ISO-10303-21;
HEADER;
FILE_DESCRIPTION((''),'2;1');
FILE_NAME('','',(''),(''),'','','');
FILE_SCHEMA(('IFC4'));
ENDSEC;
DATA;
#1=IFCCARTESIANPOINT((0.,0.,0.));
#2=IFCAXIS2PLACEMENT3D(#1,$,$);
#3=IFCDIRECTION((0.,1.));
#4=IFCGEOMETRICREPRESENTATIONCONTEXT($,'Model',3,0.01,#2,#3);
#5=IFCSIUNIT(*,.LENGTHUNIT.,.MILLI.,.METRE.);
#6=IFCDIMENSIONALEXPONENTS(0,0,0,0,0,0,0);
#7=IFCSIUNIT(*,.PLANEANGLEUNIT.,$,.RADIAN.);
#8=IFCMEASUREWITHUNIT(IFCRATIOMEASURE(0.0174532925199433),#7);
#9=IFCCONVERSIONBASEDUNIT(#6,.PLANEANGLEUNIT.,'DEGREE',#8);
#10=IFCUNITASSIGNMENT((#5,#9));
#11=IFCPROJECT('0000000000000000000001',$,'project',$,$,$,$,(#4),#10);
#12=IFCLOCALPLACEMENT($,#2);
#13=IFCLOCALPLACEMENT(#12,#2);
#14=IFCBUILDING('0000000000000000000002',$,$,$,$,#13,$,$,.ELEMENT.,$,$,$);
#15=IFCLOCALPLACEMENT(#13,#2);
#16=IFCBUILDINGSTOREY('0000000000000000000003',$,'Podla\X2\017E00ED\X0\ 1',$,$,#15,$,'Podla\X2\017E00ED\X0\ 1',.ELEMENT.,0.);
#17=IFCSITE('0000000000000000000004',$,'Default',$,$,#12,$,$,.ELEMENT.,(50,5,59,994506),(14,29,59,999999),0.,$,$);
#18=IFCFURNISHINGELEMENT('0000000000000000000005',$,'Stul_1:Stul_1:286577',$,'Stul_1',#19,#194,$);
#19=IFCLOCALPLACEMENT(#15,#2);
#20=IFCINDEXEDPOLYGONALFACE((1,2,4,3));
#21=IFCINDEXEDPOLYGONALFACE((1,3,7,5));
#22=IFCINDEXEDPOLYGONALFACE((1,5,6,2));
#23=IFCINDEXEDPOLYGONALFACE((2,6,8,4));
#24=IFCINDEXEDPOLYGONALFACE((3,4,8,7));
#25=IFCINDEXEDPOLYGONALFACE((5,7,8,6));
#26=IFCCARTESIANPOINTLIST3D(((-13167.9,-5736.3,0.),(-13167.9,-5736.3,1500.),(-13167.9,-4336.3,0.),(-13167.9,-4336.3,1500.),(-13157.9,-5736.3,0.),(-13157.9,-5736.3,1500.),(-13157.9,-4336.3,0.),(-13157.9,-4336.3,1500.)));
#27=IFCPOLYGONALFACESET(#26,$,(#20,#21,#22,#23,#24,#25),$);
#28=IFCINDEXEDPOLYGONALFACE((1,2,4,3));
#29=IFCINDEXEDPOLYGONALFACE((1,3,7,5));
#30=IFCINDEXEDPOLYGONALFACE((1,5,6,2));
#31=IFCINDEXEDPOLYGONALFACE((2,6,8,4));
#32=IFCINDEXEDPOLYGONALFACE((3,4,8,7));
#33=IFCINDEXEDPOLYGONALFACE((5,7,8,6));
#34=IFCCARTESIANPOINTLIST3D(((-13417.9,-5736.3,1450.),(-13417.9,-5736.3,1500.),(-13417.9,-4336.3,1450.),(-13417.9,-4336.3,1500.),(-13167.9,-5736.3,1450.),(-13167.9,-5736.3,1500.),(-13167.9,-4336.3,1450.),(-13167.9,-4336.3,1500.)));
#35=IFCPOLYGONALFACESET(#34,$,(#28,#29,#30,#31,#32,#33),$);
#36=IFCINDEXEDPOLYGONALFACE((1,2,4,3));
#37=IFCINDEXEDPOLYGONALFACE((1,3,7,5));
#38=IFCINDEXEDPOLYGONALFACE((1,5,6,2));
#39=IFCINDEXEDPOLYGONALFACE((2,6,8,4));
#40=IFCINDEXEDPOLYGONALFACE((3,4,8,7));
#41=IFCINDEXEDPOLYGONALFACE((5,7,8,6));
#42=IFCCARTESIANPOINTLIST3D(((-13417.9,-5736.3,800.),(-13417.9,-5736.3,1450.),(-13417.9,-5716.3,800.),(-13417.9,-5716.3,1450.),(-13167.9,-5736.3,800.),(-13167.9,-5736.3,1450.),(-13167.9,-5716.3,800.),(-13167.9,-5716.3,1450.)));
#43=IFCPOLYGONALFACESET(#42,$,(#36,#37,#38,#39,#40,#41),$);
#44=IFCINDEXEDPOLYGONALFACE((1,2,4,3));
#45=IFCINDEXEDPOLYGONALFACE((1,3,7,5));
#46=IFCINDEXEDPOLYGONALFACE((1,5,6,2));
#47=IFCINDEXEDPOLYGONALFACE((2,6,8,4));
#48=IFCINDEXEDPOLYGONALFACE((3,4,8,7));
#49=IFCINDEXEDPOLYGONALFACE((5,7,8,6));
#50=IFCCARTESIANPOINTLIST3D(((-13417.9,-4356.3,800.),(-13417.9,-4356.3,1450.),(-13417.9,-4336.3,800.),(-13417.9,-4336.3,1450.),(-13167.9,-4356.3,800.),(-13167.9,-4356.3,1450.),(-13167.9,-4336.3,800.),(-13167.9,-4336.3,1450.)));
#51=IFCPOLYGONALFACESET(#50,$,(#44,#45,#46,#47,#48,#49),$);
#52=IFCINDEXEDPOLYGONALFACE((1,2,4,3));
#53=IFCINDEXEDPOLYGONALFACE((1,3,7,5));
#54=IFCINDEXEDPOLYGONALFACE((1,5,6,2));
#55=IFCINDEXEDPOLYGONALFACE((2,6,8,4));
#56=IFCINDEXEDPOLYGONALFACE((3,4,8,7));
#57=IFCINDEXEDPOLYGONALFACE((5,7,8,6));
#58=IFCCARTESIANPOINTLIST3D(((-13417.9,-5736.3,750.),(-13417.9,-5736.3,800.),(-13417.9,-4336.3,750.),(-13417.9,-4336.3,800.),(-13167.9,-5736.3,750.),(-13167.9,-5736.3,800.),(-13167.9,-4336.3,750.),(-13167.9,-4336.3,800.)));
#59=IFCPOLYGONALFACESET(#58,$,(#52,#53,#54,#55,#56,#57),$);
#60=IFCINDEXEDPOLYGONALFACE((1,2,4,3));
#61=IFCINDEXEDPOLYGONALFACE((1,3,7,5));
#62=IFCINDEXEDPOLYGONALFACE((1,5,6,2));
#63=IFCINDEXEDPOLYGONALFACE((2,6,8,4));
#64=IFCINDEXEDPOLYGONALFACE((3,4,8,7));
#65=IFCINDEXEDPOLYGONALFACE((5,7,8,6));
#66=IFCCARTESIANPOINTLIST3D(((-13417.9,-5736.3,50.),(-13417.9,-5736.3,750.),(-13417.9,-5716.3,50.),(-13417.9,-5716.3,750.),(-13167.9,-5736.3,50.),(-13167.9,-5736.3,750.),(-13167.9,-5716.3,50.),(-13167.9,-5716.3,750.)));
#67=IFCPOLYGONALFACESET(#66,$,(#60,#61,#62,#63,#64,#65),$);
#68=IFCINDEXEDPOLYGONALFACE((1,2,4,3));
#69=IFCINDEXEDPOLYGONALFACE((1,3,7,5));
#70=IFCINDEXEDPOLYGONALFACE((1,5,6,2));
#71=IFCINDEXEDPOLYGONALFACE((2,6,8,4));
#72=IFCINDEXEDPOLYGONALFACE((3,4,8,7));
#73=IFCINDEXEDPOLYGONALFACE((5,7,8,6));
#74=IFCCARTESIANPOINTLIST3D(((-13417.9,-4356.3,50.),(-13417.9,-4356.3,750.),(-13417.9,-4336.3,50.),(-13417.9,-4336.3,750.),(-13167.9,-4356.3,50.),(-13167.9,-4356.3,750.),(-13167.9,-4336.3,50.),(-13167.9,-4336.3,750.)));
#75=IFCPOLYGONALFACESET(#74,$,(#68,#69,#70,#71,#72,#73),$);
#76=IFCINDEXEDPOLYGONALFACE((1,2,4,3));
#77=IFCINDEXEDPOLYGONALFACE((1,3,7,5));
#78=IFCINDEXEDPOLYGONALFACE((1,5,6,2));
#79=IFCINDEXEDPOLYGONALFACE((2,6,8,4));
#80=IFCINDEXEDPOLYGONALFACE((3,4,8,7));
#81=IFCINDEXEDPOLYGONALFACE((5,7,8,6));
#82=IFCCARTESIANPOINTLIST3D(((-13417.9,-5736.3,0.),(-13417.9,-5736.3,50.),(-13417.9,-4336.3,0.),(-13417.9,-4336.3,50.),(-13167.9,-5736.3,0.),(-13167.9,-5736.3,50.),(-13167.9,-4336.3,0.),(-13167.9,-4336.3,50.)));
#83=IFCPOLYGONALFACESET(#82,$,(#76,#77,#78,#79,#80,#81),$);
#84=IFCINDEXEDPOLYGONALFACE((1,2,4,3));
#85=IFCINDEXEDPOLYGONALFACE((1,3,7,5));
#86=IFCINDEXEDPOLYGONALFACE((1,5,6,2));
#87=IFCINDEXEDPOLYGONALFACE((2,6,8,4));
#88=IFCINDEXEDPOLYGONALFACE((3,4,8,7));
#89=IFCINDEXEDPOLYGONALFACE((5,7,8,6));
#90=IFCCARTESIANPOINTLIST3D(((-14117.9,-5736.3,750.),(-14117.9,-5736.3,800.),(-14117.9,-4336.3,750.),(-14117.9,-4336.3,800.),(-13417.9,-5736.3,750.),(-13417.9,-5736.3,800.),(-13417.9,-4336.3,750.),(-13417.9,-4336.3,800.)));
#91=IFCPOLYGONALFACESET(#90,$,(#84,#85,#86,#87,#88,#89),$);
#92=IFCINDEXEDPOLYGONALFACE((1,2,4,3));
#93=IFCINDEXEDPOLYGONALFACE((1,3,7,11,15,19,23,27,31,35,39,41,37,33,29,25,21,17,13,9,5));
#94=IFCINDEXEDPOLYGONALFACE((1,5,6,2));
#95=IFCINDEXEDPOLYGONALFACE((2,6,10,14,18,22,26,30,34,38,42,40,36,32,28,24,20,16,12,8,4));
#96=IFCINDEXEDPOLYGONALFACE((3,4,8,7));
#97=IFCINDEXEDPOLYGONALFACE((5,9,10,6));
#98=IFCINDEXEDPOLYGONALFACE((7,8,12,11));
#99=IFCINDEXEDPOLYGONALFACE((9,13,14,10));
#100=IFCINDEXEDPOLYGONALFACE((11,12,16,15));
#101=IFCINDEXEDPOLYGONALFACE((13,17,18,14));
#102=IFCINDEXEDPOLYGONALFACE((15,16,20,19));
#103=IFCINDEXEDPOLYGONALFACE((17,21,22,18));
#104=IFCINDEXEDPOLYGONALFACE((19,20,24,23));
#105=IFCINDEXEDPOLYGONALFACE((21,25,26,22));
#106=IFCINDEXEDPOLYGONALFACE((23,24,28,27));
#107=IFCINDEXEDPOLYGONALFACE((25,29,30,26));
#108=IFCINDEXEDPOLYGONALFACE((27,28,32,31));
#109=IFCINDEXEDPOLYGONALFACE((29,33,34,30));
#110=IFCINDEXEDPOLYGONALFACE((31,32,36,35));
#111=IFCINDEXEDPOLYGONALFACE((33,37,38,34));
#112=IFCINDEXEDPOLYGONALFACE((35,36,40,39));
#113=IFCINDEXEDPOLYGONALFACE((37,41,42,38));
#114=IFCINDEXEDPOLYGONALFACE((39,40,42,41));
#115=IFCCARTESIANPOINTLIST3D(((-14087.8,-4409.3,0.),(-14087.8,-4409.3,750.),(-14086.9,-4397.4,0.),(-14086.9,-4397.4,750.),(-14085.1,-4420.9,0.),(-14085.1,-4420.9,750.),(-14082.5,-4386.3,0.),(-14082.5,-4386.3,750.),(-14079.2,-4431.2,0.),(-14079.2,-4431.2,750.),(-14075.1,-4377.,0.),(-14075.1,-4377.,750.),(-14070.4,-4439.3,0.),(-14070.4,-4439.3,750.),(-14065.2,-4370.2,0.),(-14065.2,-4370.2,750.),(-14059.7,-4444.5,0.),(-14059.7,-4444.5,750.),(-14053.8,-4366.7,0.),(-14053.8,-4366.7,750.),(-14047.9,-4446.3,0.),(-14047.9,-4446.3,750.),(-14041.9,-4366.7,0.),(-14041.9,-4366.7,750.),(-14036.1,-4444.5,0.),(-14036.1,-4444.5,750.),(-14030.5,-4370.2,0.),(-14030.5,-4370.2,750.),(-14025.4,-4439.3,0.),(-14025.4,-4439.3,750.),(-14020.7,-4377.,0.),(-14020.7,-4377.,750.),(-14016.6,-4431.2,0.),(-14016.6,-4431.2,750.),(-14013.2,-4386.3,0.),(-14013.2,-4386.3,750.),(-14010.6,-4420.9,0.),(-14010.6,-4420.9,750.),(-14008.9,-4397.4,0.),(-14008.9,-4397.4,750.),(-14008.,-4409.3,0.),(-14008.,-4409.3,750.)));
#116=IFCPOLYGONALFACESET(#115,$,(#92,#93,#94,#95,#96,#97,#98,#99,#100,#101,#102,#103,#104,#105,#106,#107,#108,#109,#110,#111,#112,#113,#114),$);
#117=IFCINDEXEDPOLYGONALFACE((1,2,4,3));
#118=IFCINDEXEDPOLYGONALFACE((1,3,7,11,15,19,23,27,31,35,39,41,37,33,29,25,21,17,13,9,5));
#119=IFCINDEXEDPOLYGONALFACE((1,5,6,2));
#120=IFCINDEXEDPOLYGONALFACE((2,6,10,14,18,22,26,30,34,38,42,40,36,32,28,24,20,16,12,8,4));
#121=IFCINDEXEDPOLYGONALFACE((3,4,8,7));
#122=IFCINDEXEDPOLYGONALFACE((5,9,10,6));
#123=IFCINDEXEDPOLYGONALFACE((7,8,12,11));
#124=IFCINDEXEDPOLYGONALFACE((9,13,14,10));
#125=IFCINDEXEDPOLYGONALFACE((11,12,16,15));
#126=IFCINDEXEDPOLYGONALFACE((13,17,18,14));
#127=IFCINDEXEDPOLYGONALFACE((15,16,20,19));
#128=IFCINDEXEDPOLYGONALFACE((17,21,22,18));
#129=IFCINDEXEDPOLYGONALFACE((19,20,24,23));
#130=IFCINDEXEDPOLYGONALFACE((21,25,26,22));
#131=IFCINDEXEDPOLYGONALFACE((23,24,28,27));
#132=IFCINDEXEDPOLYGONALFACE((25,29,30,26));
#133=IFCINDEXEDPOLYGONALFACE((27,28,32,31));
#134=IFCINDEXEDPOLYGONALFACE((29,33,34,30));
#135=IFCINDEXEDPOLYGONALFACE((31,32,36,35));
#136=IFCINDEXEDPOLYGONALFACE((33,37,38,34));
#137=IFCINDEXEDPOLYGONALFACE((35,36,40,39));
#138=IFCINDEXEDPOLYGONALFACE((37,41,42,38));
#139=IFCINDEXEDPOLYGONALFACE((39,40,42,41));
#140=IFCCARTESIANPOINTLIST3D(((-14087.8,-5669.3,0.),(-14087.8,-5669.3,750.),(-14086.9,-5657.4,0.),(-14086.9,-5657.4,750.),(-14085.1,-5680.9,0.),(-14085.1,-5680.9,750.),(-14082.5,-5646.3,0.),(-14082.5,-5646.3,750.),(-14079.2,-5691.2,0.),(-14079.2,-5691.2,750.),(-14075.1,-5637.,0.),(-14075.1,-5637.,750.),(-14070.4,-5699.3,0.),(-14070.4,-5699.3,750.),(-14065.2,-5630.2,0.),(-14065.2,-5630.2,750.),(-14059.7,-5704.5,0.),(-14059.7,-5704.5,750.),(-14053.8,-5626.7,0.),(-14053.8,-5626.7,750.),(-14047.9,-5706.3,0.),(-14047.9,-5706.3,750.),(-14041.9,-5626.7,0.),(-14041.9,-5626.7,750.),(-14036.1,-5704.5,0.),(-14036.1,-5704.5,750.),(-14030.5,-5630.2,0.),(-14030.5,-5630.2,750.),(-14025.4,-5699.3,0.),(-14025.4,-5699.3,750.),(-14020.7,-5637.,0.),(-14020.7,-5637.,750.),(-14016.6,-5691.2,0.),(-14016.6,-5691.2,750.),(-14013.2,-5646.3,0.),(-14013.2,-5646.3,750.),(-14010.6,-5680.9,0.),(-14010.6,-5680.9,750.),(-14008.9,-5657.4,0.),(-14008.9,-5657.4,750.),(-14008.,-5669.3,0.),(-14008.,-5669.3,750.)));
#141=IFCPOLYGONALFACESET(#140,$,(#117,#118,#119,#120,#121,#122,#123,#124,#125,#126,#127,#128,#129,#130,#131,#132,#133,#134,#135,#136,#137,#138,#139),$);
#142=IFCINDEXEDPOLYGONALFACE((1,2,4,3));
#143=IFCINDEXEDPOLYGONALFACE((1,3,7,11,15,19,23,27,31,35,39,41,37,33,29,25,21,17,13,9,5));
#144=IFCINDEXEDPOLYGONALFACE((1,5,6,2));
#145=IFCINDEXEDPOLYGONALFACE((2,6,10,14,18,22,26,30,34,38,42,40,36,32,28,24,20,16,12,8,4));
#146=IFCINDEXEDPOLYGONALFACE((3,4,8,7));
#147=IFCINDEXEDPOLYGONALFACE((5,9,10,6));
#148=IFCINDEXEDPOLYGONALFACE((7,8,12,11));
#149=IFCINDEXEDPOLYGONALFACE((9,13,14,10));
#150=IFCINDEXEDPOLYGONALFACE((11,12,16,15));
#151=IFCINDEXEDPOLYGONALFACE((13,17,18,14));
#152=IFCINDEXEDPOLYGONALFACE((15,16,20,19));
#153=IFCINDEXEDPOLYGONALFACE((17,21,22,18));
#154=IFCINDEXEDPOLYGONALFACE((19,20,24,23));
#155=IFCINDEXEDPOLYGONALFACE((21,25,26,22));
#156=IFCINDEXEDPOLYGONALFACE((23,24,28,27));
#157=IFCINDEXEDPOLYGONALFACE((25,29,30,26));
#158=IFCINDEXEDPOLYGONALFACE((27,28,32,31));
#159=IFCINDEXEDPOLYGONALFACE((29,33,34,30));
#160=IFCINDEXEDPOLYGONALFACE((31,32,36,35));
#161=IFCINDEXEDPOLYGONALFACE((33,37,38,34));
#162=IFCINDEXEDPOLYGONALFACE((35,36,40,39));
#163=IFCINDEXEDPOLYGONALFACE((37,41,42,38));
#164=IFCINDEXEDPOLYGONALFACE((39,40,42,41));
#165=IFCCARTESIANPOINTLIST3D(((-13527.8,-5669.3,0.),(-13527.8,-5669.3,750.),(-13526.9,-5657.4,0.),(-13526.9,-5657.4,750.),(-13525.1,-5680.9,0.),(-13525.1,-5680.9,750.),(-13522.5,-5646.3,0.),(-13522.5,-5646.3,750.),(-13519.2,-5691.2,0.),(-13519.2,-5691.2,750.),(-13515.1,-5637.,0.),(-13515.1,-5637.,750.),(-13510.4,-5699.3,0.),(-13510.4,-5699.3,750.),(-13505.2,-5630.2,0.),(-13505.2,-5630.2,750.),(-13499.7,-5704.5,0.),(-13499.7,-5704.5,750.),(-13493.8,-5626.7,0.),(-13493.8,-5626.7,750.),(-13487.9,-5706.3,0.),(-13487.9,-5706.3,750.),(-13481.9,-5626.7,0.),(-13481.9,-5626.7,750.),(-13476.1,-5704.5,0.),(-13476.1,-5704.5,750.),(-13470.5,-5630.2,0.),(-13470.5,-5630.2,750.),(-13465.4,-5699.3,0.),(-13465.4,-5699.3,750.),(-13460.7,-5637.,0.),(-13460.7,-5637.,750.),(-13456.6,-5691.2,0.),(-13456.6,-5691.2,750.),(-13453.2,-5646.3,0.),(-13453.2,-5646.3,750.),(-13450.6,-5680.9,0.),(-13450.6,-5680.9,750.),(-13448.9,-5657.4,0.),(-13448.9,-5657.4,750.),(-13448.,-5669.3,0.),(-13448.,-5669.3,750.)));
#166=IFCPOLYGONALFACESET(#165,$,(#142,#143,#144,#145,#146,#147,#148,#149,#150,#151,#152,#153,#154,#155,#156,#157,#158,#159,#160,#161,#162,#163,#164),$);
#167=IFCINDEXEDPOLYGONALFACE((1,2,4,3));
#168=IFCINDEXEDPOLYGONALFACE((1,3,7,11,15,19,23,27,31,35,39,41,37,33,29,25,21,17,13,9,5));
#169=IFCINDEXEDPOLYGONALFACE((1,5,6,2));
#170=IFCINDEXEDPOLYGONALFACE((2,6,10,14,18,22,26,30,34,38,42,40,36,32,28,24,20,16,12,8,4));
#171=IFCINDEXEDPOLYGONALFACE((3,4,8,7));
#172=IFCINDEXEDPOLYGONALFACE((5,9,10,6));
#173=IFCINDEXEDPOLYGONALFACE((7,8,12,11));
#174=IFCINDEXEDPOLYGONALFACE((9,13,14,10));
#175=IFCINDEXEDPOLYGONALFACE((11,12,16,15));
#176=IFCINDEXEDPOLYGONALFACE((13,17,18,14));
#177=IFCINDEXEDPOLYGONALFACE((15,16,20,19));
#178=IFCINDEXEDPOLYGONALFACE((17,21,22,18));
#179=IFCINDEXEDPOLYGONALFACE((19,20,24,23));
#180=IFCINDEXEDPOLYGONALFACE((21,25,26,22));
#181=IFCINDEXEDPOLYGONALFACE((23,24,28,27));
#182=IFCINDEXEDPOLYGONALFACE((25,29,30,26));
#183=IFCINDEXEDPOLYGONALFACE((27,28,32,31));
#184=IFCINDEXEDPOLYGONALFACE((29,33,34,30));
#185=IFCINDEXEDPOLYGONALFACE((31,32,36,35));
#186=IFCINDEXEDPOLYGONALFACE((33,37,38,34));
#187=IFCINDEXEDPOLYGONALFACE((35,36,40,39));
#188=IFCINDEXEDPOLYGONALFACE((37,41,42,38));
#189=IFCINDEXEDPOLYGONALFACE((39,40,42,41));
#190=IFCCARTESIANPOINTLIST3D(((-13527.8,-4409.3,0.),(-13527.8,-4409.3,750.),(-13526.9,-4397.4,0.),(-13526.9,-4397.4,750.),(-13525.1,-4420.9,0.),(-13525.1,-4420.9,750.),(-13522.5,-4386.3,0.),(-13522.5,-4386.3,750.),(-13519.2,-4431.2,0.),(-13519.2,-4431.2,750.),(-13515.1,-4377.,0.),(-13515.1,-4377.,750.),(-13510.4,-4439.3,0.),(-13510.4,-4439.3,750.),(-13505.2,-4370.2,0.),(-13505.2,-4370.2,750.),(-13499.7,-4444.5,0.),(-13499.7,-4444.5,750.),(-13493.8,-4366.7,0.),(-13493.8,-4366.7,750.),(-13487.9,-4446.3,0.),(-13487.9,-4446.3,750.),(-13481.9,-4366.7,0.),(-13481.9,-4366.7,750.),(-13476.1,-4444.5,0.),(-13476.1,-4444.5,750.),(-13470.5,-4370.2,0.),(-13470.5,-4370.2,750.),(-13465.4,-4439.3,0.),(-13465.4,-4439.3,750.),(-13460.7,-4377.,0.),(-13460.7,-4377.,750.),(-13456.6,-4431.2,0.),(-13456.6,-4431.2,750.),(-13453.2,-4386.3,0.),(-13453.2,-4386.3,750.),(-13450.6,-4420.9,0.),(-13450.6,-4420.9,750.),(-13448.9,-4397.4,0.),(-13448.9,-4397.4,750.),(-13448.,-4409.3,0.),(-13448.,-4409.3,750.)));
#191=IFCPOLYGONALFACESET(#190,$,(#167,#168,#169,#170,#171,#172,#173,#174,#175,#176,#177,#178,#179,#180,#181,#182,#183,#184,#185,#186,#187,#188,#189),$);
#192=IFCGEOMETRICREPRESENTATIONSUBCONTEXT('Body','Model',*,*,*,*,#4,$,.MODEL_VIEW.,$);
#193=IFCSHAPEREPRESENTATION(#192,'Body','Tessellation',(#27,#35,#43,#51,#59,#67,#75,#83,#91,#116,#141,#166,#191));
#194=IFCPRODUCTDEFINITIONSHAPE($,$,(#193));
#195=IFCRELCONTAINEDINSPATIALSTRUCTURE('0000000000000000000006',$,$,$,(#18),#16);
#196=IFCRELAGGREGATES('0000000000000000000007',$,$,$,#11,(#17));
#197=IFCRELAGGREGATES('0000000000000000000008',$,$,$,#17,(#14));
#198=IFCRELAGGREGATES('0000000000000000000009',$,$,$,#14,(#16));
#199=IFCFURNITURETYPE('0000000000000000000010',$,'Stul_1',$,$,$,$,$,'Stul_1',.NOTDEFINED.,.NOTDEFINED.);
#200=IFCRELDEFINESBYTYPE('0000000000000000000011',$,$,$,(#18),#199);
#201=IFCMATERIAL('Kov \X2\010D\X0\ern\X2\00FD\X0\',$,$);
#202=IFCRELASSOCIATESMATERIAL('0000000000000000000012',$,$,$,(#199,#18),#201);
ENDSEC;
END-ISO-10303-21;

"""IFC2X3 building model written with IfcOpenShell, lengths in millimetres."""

from ifc_helpers import new_model, entity, si_unit, converted_unit, direction, frame, frame_2d, origin, origin_2d_with_axis, place, context, subcontext, project, spatial, rectangle, circle, extrude, source, transform, mapped, material, type_object, type_shapes, element, save


model = new_model("IFC2X3")

# Units and contexts
model_context = context("Model", 3, precision=0.01, world=origin(), true_north=direction((0.0, 1.0)))
body_context = subcontext(model_context, "Body", "Model", "MODEL_VIEW")
ifc_project = project(units=[si_unit("LENGTHUNIT", "METRE", prefix="MILLI"), converted_unit("PLANEANGLEUNIT", "DEGREE", entity("IfcRatioMeasure", 0.0174532925199433), si_unit("PLANEANGLEUNIT", "RADIAN"), dimensions=[0, 0, 0, 0, 0, 0, 0])], contexts=[model_context])

# Site, building, storey
site_placement = place(None, origin())
site = spatial("IfcSite", under=ifc_project, at=site_placement, Name="Default", CompositionType="ELEMENT", RefLatitude=(50, 5, 59, 994506), RefLongitude=(14, 29, 59, 999999), RefElevation=0.0)
building_placement = place(site_placement, origin())
building = spatial("IfcBuilding", under=site, at=building_placement, CompositionType="ELEMENT")
storey_placement = place(building_placement, origin())
storey = spatial("IfcBuildingStorey", under=building, at=storey_placement, Name="Podlaží 1", LongName="Podlaží 1", CompositionType="ELEMENT", Elevation=0.0)

# Furnishing element
ifc_material_1 = material(Name="Kov černý")
furniture_type = type_object("IfcFurnitureType", Name="Stul_1", ElementType="Stul_1", material=ifc_material_1)
shared_shape_1 = source(origin(), body_context, "Body", "SweptSolid", [
    extrude(rectangle(XDim=1400.0, YDim=10.0, at=origin_2d_with_axis()), frame((0.0, 605.0, 0.0), z_axis=(0.0, 0.0, 1.0), x_axis=(-1.0, 0.0, 0.0)), (0.0, 0.0, 1.0), 1500.0),
    extrude(rectangle(XDim=1400.0, YDim=250.0, at=frame_2d((0.0, 0.0), x_axis=(1.0, 0.0))), frame((0.0, 475.0, 1450.0), z_axis=(0.0, 0.0, 1.0), x_axis=(-1.0, 0.0, 0.0)), (0.0, 0.0, 1.0), 50.0),
    extrude(rectangle(XDim=20.0, YDim=250.0, at=origin_2d_with_axis()), frame((690.0, 475.0, 800.0), z_axis=(0.0, 0.0, 1.0), x_axis=(-1.0, 0.0, 0.0)), (0.0, 0.0, 1.0), 650.0),
    extrude(rectangle(XDim=20.0, YDim=250.0, at=frame_2d((0.0, 0.0), x_axis=(1.0, 0.0))), frame((-690.0, 475.0, 800.0), z_axis=(0.0, 0.0, 1.0), x_axis=(-1.0, 0.0, 0.0)), (0.0, 0.0, 1.0), 650.0),
    extrude(rectangle(XDim=1400.0, YDim=250.0, at=origin_2d_with_axis()), frame((0.0, 475.0, 750.0), z_axis=(0.0, 0.0, 1.0), x_axis=(-1.0, 0.0, 0.0)), (0.0, 0.0, 1.0), 50.0),
    extrude(rectangle(XDim=20.0, YDim=250.0, at=origin_2d_with_axis()), frame((690.0, 475.0, 50.0), z_axis=(0.0, 0.0, 1.0), x_axis=(-1.0, 0.0, 0.0)), (0.0, 0.0, 1.0), 700.0),
    extrude(rectangle(XDim=20.0, YDim=250.0, at=frame_2d((0.0, 0.0), x_axis=(1.0, 0.0))), frame((-690.0, 475.0, 50.0), z_axis=(0.0, 0.0, 1.0), x_axis=(-1.0, 0.0, 0.0)), (0.0, 0.0, 1.0), 700.0),
    extrude(rectangle(XDim=1400.0, YDim=250.0, at=origin_2d_with_axis()), frame((0.0, 475.0, 0.0), z_axis=(0.0, 0.0, 1.0), x_axis=(-1.0, 0.0, 0.0)), (0.0, 0.0, 1.0), 50.0),
    extrude(rectangle(XDim=1400.0, YDim=700.0, at=origin_2d_with_axis()), frame((0.0, 0.0, 750.0), z_axis=(0.0, 0.0, 1.0), x_axis=(-1.0, 0.0, 0.0)), (0.0, 0.0, 1.0), 50.0),
    extrude(circle(Radius=40.0, at=frame_2d((0.0, 0.0), x_axis=(1.0, 0.0))), frame((-630.0, -280.0, 0.0)), (0.0, 0.0, 1.0), 750.0),
    extrude(circle(Radius=40.0, at=frame_2d((0.0, 0.0), x_axis=(1.0, 0.0))), frame((630.0, -280.0, 0.0)), (0.0, 0.0, 1.0), 750.0),
    extrude(circle(Radius=40.0, at=frame_2d((0.0, 0.0), x_axis=(1.0, 0.0))), frame((630.0, 280.0, 0.0)), (0.0, 0.0, 1.0), 750.0),
    extrude(circle(Radius=40.0, at=frame_2d((0.0, 0.0), x_axis=(1.0, 0.0))), frame((-630.0, 280.0, 0.0)), (0.0, 0.0, 1.0), 750.0),
])
type_shapes(furniture_type, [shared_shape_1])
for number, where, z_axis, x_axis, name in (
    (1, (-13767.9, -5036.3, 0.0), (0.0, 0.0, 1.0), (0.0, -1.0, 0.0), "Stul_1:Stul_1:286577"),
):
    element("IfcFurnishingElement", number, at=place(storey_placement, frame(where, z_axis=z_axis, x_axis=x_axis)), inside=storey, type_object=furniture_type, material=ifc_material_1, Name=name, ObjectType="Stul_1", context=body_context, shape_type="MappedRepresentation", body=[
        mapped(shared_shape_1, transform((0.0, 0.0, 0.0), scale=1.0)),
    ])

save(model, "model.ifc")
